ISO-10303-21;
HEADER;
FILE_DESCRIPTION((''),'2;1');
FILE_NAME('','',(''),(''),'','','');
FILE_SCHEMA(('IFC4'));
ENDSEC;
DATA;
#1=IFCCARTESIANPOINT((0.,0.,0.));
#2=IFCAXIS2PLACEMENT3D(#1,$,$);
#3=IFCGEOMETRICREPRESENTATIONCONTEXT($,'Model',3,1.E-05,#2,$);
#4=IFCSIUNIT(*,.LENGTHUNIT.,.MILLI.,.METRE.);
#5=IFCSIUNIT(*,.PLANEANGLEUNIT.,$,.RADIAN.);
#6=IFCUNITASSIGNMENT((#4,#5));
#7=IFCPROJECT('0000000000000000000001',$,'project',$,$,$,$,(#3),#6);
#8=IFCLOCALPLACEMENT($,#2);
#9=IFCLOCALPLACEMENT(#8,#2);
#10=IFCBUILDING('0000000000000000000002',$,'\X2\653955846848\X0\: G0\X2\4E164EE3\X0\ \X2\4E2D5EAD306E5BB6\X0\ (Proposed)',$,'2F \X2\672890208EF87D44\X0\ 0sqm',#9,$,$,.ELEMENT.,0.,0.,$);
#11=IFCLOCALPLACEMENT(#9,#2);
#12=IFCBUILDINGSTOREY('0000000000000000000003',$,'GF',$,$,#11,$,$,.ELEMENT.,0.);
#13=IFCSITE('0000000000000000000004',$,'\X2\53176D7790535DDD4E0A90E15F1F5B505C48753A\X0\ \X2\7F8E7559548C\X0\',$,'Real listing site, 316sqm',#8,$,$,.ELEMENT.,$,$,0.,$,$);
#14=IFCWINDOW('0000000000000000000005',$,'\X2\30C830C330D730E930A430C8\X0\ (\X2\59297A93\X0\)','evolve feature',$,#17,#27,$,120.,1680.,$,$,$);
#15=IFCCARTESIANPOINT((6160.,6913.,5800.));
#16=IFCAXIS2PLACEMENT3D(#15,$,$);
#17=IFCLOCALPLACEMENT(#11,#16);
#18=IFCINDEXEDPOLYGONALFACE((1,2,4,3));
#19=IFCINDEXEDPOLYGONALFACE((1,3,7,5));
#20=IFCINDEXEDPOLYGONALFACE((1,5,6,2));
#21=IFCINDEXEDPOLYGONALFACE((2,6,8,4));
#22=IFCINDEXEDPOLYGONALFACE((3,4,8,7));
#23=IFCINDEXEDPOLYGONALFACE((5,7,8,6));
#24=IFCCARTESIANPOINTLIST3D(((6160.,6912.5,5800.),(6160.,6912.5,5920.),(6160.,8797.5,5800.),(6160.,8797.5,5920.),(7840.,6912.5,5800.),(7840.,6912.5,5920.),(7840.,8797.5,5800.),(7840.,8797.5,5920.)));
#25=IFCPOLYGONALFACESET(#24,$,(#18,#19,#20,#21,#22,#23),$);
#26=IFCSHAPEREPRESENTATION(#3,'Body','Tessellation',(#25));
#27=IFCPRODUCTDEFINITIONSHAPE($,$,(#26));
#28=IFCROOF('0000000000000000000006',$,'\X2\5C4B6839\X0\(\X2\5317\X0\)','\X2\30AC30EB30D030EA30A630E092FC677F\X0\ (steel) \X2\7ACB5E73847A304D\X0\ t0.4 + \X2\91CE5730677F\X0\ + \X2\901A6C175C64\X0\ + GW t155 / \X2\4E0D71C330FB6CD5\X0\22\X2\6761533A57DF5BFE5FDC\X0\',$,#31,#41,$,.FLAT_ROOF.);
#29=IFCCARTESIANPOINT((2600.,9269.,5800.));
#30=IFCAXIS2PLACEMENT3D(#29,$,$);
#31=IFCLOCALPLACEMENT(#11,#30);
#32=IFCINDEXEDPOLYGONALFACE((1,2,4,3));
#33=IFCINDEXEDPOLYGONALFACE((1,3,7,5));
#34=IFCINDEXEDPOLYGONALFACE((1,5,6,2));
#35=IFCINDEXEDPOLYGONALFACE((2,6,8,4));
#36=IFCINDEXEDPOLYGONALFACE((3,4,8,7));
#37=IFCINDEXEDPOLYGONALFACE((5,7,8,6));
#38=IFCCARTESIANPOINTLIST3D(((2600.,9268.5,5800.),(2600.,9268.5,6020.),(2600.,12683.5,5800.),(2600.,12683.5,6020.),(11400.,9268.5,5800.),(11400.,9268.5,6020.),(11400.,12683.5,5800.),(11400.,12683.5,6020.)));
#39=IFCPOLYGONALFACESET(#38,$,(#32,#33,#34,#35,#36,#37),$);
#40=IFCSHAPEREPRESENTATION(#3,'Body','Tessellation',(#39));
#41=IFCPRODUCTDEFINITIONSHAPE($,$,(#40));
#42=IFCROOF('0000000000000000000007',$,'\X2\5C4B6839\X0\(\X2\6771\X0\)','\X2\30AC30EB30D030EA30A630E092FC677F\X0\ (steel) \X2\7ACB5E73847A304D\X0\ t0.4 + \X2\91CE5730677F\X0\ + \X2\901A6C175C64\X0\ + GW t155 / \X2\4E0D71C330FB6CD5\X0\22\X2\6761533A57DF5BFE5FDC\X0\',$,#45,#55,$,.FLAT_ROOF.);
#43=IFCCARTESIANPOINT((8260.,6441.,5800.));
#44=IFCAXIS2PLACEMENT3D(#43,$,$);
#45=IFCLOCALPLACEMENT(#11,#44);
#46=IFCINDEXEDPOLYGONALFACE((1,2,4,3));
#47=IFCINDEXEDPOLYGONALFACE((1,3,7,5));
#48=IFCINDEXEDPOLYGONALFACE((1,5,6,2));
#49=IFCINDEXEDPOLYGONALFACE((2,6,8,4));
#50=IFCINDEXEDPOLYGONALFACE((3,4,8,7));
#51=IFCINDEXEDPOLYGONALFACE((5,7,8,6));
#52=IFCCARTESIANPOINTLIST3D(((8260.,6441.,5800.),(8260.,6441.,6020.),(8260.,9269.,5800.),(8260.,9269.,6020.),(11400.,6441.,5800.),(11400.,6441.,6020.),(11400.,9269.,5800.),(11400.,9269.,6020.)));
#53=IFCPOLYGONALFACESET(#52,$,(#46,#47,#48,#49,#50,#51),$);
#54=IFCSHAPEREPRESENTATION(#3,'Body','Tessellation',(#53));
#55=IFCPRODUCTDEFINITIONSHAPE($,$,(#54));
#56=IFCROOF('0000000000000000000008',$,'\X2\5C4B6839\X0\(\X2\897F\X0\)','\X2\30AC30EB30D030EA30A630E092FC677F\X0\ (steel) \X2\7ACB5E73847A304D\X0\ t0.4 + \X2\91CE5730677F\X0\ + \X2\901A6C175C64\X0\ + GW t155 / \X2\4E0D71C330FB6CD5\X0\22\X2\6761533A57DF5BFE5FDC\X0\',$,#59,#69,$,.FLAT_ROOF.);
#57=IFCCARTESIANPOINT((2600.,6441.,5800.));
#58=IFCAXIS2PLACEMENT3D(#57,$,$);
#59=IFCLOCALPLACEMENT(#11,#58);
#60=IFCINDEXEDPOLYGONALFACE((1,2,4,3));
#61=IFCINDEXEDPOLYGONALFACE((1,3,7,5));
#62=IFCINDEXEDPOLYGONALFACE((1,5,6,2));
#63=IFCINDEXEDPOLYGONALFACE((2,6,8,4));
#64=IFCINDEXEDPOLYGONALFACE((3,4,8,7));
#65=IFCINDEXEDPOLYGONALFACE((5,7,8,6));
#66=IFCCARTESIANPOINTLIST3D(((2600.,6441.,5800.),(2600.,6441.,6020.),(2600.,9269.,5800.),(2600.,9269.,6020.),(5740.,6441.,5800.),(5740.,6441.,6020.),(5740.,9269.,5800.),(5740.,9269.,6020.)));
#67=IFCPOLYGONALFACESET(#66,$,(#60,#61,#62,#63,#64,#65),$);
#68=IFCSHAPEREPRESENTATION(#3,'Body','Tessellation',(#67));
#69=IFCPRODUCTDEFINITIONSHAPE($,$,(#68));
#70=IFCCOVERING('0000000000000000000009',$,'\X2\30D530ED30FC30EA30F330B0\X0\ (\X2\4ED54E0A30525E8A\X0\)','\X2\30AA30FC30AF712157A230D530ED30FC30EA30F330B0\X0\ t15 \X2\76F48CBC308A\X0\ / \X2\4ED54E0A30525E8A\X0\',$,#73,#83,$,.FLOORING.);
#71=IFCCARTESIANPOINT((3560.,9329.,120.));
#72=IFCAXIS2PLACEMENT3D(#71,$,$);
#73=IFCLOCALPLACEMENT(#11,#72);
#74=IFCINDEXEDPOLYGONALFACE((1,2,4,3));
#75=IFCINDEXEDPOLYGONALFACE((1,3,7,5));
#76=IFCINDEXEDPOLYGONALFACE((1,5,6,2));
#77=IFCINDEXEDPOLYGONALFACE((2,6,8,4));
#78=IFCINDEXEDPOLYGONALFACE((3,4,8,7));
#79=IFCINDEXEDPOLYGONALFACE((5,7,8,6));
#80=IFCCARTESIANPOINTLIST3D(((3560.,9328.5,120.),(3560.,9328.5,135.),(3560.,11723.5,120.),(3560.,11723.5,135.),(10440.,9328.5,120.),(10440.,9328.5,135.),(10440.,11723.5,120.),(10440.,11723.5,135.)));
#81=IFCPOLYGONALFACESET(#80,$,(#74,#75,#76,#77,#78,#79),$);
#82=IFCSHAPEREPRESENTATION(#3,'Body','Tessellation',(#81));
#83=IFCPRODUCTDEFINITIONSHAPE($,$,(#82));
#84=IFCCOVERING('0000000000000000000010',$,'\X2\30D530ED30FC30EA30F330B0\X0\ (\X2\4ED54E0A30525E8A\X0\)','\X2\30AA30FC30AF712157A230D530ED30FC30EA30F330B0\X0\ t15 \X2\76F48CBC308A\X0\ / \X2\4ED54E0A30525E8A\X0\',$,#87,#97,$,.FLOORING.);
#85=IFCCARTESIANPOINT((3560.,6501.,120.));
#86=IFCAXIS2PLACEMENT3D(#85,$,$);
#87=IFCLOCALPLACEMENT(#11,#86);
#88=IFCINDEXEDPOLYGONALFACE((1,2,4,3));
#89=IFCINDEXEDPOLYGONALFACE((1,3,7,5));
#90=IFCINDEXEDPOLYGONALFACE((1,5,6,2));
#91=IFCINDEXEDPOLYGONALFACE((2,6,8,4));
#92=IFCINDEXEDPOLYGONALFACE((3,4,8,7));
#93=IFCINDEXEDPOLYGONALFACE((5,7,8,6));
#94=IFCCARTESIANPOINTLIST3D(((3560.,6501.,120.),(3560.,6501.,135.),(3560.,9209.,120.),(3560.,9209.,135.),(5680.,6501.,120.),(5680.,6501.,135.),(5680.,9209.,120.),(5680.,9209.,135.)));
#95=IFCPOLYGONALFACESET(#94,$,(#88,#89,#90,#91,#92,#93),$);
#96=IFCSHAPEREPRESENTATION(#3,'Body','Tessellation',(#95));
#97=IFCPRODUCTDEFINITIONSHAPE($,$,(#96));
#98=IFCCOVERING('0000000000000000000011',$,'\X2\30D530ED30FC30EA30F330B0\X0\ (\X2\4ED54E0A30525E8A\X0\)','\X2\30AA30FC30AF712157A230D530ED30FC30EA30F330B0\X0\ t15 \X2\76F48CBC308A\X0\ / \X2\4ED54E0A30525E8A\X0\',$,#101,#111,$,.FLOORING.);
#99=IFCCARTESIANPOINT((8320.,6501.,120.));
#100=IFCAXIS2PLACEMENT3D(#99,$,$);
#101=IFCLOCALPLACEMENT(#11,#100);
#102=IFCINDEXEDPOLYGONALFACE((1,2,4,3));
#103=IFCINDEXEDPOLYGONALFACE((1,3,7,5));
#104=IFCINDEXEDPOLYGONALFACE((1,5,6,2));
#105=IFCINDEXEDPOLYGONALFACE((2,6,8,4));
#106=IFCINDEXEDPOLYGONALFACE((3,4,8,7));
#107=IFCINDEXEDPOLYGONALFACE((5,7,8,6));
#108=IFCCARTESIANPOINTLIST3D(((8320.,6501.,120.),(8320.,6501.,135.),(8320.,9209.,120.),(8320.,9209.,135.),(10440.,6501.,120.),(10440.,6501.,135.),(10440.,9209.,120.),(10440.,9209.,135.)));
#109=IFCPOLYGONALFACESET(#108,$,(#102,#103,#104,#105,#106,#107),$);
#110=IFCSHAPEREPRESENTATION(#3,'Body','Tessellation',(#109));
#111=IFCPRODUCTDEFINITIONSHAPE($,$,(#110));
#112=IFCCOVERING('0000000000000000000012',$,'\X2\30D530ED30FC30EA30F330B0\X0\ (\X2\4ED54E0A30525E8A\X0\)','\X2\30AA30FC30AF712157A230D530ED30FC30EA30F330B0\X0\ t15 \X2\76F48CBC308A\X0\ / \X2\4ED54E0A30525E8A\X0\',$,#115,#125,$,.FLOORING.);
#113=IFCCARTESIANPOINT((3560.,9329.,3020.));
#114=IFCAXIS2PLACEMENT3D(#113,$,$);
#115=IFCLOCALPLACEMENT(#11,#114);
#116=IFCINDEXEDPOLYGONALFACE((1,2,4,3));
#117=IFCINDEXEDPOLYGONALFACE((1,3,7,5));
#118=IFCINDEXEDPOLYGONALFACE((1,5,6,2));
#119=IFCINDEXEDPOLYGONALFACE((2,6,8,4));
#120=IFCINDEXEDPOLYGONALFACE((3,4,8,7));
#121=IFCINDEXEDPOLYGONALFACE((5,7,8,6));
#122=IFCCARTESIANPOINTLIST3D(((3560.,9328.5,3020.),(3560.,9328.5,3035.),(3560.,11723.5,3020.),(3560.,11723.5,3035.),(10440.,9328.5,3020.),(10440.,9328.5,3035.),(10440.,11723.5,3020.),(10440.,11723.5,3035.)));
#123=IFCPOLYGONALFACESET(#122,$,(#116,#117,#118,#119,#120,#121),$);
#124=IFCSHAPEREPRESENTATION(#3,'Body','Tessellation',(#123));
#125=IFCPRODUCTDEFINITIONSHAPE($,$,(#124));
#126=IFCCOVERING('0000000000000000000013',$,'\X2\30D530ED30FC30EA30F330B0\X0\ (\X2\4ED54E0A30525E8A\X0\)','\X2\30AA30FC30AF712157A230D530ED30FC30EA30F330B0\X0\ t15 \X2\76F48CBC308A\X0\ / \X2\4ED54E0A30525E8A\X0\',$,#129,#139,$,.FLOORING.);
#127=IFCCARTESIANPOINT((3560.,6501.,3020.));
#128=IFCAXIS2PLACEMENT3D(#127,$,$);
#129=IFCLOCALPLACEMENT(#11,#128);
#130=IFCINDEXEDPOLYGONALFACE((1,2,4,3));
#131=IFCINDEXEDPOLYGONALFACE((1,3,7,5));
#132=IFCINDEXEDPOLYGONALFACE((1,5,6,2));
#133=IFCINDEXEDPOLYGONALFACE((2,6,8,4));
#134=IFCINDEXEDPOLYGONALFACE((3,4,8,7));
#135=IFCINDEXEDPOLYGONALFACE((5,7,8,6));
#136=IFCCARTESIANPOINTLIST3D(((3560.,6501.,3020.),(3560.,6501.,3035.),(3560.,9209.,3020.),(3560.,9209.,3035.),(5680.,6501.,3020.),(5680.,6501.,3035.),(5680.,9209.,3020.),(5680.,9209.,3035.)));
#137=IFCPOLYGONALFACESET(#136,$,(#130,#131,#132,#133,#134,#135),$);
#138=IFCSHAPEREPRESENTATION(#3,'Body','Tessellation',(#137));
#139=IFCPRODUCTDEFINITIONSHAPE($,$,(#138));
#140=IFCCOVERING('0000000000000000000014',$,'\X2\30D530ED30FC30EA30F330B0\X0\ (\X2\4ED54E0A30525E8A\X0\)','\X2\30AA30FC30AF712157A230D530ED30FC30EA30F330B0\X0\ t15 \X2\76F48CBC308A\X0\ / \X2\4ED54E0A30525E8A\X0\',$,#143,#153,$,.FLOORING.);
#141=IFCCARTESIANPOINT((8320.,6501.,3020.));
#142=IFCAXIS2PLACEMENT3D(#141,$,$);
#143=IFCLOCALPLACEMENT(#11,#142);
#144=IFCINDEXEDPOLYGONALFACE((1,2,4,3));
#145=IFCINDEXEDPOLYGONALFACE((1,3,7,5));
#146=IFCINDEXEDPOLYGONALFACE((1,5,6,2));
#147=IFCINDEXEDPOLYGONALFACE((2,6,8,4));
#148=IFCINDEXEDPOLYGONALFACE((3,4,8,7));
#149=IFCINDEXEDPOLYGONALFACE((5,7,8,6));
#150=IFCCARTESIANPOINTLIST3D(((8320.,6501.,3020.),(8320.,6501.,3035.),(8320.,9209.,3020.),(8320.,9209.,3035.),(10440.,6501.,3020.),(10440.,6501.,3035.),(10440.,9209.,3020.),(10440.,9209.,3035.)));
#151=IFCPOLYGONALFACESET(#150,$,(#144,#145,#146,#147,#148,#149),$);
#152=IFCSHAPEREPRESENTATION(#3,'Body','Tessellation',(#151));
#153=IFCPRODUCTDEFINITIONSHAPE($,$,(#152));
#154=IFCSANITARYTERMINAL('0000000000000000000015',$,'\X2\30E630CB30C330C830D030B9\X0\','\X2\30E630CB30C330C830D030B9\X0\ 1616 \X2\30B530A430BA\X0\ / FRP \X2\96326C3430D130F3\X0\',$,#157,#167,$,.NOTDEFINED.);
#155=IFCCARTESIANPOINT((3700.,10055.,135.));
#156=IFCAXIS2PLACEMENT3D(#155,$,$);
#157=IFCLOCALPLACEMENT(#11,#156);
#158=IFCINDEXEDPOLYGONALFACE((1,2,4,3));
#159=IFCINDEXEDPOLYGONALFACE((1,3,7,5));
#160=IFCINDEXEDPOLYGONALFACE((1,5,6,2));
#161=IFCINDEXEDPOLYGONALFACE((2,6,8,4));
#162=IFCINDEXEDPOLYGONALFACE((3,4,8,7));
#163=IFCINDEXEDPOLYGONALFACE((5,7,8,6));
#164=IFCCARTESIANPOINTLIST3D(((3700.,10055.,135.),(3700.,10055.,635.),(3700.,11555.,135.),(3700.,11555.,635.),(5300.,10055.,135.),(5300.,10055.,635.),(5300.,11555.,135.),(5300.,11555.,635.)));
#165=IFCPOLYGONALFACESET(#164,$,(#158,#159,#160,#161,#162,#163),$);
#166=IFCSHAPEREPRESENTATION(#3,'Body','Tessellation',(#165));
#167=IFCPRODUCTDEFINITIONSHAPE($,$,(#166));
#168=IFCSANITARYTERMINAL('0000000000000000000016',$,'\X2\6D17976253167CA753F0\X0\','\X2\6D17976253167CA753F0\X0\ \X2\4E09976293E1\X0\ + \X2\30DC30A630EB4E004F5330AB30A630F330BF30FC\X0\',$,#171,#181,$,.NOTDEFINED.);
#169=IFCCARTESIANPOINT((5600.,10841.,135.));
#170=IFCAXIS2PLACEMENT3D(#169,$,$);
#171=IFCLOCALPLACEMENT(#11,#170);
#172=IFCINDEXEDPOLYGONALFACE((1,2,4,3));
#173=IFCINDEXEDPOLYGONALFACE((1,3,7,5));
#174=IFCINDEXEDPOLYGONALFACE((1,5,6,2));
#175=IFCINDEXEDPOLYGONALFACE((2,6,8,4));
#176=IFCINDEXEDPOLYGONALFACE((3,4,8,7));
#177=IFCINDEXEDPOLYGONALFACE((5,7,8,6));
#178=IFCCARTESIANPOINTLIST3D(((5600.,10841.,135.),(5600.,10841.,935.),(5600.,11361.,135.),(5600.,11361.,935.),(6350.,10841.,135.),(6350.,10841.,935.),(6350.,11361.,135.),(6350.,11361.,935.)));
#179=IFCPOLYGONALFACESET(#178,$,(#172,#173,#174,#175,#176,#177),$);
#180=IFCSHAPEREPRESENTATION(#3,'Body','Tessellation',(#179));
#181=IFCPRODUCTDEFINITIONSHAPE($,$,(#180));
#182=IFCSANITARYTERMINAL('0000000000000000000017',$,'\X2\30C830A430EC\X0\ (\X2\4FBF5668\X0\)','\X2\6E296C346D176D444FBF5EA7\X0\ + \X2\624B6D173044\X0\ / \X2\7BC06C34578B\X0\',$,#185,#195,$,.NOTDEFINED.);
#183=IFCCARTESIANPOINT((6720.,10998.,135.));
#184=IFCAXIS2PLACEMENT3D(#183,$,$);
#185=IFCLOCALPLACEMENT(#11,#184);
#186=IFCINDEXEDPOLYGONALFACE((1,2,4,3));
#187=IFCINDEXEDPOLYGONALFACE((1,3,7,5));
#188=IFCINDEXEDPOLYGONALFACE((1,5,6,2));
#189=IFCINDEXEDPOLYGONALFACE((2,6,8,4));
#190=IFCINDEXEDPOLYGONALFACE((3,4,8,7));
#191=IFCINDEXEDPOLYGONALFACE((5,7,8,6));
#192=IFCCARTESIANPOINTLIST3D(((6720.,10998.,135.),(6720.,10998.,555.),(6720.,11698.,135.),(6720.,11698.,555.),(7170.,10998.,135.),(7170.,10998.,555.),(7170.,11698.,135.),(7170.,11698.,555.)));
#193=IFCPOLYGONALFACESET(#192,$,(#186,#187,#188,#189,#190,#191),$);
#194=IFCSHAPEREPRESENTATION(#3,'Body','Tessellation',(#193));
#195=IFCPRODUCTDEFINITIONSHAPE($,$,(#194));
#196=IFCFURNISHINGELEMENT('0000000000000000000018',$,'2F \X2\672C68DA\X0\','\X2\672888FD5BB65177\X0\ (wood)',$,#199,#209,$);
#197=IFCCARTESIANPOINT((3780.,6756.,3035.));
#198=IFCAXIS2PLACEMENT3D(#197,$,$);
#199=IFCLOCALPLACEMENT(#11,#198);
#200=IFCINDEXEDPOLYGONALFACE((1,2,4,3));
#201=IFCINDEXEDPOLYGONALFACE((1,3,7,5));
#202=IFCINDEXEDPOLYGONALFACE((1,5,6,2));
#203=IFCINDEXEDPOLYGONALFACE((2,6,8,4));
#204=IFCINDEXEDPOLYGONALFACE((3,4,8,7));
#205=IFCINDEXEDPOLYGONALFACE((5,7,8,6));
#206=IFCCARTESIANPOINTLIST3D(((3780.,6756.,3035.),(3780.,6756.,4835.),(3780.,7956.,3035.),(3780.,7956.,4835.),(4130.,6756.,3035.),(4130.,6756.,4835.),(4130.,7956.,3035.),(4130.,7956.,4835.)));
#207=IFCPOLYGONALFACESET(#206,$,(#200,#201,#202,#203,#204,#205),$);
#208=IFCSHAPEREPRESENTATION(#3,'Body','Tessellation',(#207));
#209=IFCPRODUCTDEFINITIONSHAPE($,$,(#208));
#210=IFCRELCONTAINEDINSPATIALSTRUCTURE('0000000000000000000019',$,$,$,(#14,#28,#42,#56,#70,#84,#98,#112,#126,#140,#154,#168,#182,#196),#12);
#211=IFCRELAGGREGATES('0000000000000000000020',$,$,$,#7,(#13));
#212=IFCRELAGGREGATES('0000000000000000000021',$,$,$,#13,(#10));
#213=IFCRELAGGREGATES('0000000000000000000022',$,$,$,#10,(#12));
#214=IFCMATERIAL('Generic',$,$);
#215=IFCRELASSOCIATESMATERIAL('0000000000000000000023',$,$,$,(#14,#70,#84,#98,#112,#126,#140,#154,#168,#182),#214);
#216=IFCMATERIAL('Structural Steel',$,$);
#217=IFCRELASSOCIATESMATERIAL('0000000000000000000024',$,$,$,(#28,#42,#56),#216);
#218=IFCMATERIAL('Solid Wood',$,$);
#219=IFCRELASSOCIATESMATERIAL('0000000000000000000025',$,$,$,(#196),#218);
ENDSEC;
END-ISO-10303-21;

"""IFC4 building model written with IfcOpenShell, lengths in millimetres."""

from ifc_helpers import new_model, si_unit, frame, frame_2d, origin, place, context, project, spatial, rectangle, extrude, material, element, save


model = new_model("IFC4")

# Units and contexts
model_context = context("Model", 3, precision=1e-05, world=origin())
ifc_project = project(units=[si_unit("LENGTHUNIT", "METRE", prefix="MILLI"), si_unit("PLANEANGLEUNIT", "RADIAN")], contexts=[model_context])

# Site, building, storey
site_placement = place(None, origin())
site = spatial("IfcSite", under=ifc_project, at=site_placement, Name="北海道川上郡弟子屈町 美留和", ObjectType="Real listing site, 316sqm", CompositionType="ELEMENT", RefElevation=0.0)
building_placement = place(site_placement, origin())
building = spatial("IfcBuilding", under=site, at=building_placement, Name="改善案: G0世代 中庭の家 (Proposed)", ObjectType="2F 木造軸組 0sqm", CompositionType="ELEMENT", ElevationOfRefHeight=0.0, ElevationOfTerrain=0.0)
storey_placement = place(building_placement, origin())
storey = spatial("IfcBuildingStorey", under=building, at=storey_placement, Name="GF", CompositionType="ELEMENT", Elevation=0.0)

# Shared definitions
ifc_material_1 = material(Name="Solid Wood")

# Window
ifc_material_2 = material(Name="Generic")
window_1_placement = place(storey_placement, frame((6160.0, 6913.0, 5800.0)))
element("IfcWindow", 1, at=window_1_placement, inside=storey, material=ifc_material_2, Name="トップライト (天窓)", Description="evolve feature", OverallHeight=120.0, OverallWidth=1680.0, context=model_context, shape_type="SweptSolid", body=[
    extrude(rectangle(XDim=1680.0, YDim=1885.0, at=frame_2d((840.0, 942.0))), frame((6160.0, 6913.0, 5800.0)), (0.0, 0.0, 1.0), 120.0),
])

# Roofs
ifc_material_3 = material(Name="Structural Steel")
roof_1_placement = place(storey_placement, frame((2600.0, 9269.0, 5800.0)))
element("IfcRoof", 2, at=roof_1_placement, inside=storey, material=ifc_material_3, Name="屋根(北)", Description="ガルバリウム鋼板 (steel) 立平葺き t0.4 + 野地板 + 通気層 + GW t155 / 不燃・法22条区域対応", PredefinedType="FLAT_ROOF", context=model_context, shape_type="SweptSolid", body=[
    extrude(rectangle(XDim=8800.0, YDim=3415.0, at=frame_2d((4400.0, 1707.0))), frame((2600.0, 9269.0, 5800.0)), (0.0, 0.0, 1.0), 220.0),
])
roof_2_placement = place(storey_placement, frame((8260.0, 6441.0, 5800.0)))
element("IfcRoof", 3, at=roof_2_placement, inside=storey, material=ifc_material_3, Name="屋根(東)", Description="ガルバリウム鋼板 (steel) 立平葺き t0.4 + 野地板 + 通気層 + GW t155 / 不燃・法22条区域対応", PredefinedType="FLAT_ROOF", context=model_context, shape_type="SweptSolid", body=[
    extrude(rectangle(XDim=3140.0, YDim=2828.0, at=frame_2d((1570.0, 1414.0))), frame((8260.0, 6441.0, 5800.0)), (0.0, 0.0, 1.0), 220.0),
])
roof_3_placement = place(storey_placement, frame((2600.0, 6441.0, 5800.0)))
element("IfcRoof", 4, at=roof_3_placement, inside=storey, material=ifc_material_3, Name="屋根(西)", Description="ガルバリウム鋼板 (steel) 立平葺き t0.4 + 野地板 + 通気層 + GW t155 / 不燃・法22条区域対応", PredefinedType="FLAT_ROOF", context=model_context, shape_type="SweptSolid", body=[
    extrude(rectangle(XDim=3140.0, YDim=2828.0, at=frame_2d((1570.0, 1414.0))), frame((2600.0, 6441.0, 5800.0)), (0.0, 0.0, 1.0), 220.0),
])

# Coverings
covering_1_placement = place(storey_placement, frame((3560.0, 9329.0, 120.0)))
element("IfcCovering", 5, at=covering_1_placement, inside=storey, material=ifc_material_2, Name="フローリング (仕上げ床)", Description="オーク無垢フローリング t15 直貼り / 仕上げ床", PredefinedType="FLOORING", context=model_context, shape_type="SweptSolid", body=[
    extrude(rectangle(XDim=6880.0, YDim=2395.0, at=frame_2d((3440.0, 1197.0))), frame((3560.0, 9329.0, 120.0)), (0.0, 0.0, 1.0), 15.0),
])
covering_2_placement = place(storey_placement, frame((3560.0, 6501.0, 120.0)))
element("IfcCovering", 6, at=covering_2_placement, inside=storey, material=ifc_material_2, Name="フローリング (仕上げ床)", Description="オーク無垢フローリング t15 直貼り / 仕上げ床", PredefinedType="FLOORING", context=model_context, shape_type="SweptSolid", body=[
    extrude(rectangle(XDim=2120.0, YDim=2708.0, at=frame_2d((1060.0, 1354.0))), frame((3560.0, 6501.0, 120.0)), (0.0, 0.0, 1.0), 15.0),
])
covering_3_placement = place(storey_placement, frame((8320.0, 6501.0, 120.0)))
element("IfcCovering", 7, at=covering_3_placement, inside=storey, material=ifc_material_2, Name="フローリング (仕上げ床)", Description="オーク無垢フローリング t15 直貼り / 仕上げ床", PredefinedType="FLOORING", context=model_context, shape_type="SweptSolid", body=[
    extrude(rectangle(XDim=2120.0, YDim=2708.0, at=frame_2d((1060.0, 1354.0))), frame((8320.0, 6501.0, 120.0)), (0.0, 0.0, 1.0), 15.0),
])
covering_4_placement = place(storey_placement, frame((3560.0, 9329.0, 3020.0)))
element("IfcCovering", 8, at=covering_4_placement, inside=storey, material=ifc_material_2, Name="フローリング (仕上げ床)", Description="オーク無垢フローリング t15 直貼り / 仕上げ床", PredefinedType="FLOORING", context=model_context, shape_type="SweptSolid", body=[
    extrude(rectangle(XDim=6880.0, YDim=2395.0, at=frame_2d((3440.0, 1197.0))), frame((3560.0, 9329.0, 3020.0)), (0.0, 0.0, 1.0), 15.0),
])
covering_5_placement = place(storey_placement, frame((3560.0, 6501.0, 3020.0)))
element("IfcCovering", 9, at=covering_5_placement, inside=storey, material=ifc_material_2, Name="フローリング (仕上げ床)", Description="オーク無垢フローリング t15 直貼り / 仕上げ床", PredefinedType="FLOORING", context=model_context, shape_type="SweptSolid", body=[
    extrude(rectangle(XDim=2120.0, YDim=2708.0, at=frame_2d((1060.0, 1354.0))), frame((3560.0, 6501.0, 3020.0)), (0.0, 0.0, 1.0), 15.0),
])
covering_6_placement = place(storey_placement, frame((8320.0, 6501.0, 3020.0)))
element("IfcCovering", 10, at=covering_6_placement, inside=storey, material=ifc_material_2, Name="フローリング (仕上げ床)", Description="オーク無垢フローリング t15 直貼り / 仕上げ床", PredefinedType="FLOORING", context=model_context, shape_type="SweptSolid", body=[
    extrude(rectangle(XDim=2120.0, YDim=2708.0, at=frame_2d((1060.0, 1354.0))), frame((8320.0, 6501.0, 3020.0)), (0.0, 0.0, 1.0), 15.0),
])

# Sanitary terminals
sanitary_terminal_1_placement = place(storey_placement, frame((3700.0, 10055.0, 135.0)))
element("IfcSanitaryTerminal", 11, at=sanitary_terminal_1_placement, inside=storey, material=ifc_material_2, Name="ユニットバス", Description="ユニットバス 1616 サイズ / FRP 防水パン", PredefinedType="NOTDEFINED", context=model_context, shape_type="SweptSolid", body=[
    extrude(rectangle(XDim=1600.0, YDim=1500.0, at=frame_2d((800.0, 750.0))), frame((3700.0, 10055.0, 135.0)), (0.0, 0.0, 1.0), 500.0),
])
sanitary_terminal_2_placement = place(storey_placement, frame((5600.0, 10841.0, 135.0)))
element("IfcSanitaryTerminal", 12, at=sanitary_terminal_2_placement, inside=storey, material=ifc_material_2, Name="洗面化粧台", Description="洗面化粧台 三面鏡 + ボウル一体カウンター", PredefinedType="NOTDEFINED", context=model_context, shape_type="SweptSolid", body=[
    extrude(rectangle(XDim=750.0, YDim=520.0, at=frame_2d((375.0, 260.0))), frame((5600.0, 10841.0, 135.0)), (0.0, 0.0, 1.0), 800.0),
])
sanitary_terminal_3_placement = place(storey_placement, frame((6720.0, 10998.0, 135.0)))
element("IfcSanitaryTerminal", 13, at=sanitary_terminal_3_placement, inside=storey, material=ifc_material_2, Name="トイレ (便器)", Description="温水洗浄便座 + 手洗い / 節水型", PredefinedType="NOTDEFINED", context=model_context, shape_type="SweptSolid", body=[
    extrude(rectangle(XDim=450.0, YDim=700.0, at=frame_2d((225.0, 350.0))), frame((6720.0, 10998.0, 135.0)), (0.0, 0.0, 1.0), 420.0),
])

# Furnishing element
furnishing_placement = place(storey_placement, frame((3780.0, 6756.0, 3035.0)))
element("IfcFurnishingElement", 14, at=furnishing_placement, inside=storey, material=ifc_material_1, Name="2F 本棚", Description="木製家具 (wood)", context=model_context, shape_type="SweptSolid", body=[
    extrude(rectangle(XDim=350.0, YDim=1200.0, at=frame_2d((175.0, 600.0))), frame((3780.0, 6756.0, 3035.0)), (0.0, 0.0, 1.0), 1800.0),
])

save(model, "model.ifc")
